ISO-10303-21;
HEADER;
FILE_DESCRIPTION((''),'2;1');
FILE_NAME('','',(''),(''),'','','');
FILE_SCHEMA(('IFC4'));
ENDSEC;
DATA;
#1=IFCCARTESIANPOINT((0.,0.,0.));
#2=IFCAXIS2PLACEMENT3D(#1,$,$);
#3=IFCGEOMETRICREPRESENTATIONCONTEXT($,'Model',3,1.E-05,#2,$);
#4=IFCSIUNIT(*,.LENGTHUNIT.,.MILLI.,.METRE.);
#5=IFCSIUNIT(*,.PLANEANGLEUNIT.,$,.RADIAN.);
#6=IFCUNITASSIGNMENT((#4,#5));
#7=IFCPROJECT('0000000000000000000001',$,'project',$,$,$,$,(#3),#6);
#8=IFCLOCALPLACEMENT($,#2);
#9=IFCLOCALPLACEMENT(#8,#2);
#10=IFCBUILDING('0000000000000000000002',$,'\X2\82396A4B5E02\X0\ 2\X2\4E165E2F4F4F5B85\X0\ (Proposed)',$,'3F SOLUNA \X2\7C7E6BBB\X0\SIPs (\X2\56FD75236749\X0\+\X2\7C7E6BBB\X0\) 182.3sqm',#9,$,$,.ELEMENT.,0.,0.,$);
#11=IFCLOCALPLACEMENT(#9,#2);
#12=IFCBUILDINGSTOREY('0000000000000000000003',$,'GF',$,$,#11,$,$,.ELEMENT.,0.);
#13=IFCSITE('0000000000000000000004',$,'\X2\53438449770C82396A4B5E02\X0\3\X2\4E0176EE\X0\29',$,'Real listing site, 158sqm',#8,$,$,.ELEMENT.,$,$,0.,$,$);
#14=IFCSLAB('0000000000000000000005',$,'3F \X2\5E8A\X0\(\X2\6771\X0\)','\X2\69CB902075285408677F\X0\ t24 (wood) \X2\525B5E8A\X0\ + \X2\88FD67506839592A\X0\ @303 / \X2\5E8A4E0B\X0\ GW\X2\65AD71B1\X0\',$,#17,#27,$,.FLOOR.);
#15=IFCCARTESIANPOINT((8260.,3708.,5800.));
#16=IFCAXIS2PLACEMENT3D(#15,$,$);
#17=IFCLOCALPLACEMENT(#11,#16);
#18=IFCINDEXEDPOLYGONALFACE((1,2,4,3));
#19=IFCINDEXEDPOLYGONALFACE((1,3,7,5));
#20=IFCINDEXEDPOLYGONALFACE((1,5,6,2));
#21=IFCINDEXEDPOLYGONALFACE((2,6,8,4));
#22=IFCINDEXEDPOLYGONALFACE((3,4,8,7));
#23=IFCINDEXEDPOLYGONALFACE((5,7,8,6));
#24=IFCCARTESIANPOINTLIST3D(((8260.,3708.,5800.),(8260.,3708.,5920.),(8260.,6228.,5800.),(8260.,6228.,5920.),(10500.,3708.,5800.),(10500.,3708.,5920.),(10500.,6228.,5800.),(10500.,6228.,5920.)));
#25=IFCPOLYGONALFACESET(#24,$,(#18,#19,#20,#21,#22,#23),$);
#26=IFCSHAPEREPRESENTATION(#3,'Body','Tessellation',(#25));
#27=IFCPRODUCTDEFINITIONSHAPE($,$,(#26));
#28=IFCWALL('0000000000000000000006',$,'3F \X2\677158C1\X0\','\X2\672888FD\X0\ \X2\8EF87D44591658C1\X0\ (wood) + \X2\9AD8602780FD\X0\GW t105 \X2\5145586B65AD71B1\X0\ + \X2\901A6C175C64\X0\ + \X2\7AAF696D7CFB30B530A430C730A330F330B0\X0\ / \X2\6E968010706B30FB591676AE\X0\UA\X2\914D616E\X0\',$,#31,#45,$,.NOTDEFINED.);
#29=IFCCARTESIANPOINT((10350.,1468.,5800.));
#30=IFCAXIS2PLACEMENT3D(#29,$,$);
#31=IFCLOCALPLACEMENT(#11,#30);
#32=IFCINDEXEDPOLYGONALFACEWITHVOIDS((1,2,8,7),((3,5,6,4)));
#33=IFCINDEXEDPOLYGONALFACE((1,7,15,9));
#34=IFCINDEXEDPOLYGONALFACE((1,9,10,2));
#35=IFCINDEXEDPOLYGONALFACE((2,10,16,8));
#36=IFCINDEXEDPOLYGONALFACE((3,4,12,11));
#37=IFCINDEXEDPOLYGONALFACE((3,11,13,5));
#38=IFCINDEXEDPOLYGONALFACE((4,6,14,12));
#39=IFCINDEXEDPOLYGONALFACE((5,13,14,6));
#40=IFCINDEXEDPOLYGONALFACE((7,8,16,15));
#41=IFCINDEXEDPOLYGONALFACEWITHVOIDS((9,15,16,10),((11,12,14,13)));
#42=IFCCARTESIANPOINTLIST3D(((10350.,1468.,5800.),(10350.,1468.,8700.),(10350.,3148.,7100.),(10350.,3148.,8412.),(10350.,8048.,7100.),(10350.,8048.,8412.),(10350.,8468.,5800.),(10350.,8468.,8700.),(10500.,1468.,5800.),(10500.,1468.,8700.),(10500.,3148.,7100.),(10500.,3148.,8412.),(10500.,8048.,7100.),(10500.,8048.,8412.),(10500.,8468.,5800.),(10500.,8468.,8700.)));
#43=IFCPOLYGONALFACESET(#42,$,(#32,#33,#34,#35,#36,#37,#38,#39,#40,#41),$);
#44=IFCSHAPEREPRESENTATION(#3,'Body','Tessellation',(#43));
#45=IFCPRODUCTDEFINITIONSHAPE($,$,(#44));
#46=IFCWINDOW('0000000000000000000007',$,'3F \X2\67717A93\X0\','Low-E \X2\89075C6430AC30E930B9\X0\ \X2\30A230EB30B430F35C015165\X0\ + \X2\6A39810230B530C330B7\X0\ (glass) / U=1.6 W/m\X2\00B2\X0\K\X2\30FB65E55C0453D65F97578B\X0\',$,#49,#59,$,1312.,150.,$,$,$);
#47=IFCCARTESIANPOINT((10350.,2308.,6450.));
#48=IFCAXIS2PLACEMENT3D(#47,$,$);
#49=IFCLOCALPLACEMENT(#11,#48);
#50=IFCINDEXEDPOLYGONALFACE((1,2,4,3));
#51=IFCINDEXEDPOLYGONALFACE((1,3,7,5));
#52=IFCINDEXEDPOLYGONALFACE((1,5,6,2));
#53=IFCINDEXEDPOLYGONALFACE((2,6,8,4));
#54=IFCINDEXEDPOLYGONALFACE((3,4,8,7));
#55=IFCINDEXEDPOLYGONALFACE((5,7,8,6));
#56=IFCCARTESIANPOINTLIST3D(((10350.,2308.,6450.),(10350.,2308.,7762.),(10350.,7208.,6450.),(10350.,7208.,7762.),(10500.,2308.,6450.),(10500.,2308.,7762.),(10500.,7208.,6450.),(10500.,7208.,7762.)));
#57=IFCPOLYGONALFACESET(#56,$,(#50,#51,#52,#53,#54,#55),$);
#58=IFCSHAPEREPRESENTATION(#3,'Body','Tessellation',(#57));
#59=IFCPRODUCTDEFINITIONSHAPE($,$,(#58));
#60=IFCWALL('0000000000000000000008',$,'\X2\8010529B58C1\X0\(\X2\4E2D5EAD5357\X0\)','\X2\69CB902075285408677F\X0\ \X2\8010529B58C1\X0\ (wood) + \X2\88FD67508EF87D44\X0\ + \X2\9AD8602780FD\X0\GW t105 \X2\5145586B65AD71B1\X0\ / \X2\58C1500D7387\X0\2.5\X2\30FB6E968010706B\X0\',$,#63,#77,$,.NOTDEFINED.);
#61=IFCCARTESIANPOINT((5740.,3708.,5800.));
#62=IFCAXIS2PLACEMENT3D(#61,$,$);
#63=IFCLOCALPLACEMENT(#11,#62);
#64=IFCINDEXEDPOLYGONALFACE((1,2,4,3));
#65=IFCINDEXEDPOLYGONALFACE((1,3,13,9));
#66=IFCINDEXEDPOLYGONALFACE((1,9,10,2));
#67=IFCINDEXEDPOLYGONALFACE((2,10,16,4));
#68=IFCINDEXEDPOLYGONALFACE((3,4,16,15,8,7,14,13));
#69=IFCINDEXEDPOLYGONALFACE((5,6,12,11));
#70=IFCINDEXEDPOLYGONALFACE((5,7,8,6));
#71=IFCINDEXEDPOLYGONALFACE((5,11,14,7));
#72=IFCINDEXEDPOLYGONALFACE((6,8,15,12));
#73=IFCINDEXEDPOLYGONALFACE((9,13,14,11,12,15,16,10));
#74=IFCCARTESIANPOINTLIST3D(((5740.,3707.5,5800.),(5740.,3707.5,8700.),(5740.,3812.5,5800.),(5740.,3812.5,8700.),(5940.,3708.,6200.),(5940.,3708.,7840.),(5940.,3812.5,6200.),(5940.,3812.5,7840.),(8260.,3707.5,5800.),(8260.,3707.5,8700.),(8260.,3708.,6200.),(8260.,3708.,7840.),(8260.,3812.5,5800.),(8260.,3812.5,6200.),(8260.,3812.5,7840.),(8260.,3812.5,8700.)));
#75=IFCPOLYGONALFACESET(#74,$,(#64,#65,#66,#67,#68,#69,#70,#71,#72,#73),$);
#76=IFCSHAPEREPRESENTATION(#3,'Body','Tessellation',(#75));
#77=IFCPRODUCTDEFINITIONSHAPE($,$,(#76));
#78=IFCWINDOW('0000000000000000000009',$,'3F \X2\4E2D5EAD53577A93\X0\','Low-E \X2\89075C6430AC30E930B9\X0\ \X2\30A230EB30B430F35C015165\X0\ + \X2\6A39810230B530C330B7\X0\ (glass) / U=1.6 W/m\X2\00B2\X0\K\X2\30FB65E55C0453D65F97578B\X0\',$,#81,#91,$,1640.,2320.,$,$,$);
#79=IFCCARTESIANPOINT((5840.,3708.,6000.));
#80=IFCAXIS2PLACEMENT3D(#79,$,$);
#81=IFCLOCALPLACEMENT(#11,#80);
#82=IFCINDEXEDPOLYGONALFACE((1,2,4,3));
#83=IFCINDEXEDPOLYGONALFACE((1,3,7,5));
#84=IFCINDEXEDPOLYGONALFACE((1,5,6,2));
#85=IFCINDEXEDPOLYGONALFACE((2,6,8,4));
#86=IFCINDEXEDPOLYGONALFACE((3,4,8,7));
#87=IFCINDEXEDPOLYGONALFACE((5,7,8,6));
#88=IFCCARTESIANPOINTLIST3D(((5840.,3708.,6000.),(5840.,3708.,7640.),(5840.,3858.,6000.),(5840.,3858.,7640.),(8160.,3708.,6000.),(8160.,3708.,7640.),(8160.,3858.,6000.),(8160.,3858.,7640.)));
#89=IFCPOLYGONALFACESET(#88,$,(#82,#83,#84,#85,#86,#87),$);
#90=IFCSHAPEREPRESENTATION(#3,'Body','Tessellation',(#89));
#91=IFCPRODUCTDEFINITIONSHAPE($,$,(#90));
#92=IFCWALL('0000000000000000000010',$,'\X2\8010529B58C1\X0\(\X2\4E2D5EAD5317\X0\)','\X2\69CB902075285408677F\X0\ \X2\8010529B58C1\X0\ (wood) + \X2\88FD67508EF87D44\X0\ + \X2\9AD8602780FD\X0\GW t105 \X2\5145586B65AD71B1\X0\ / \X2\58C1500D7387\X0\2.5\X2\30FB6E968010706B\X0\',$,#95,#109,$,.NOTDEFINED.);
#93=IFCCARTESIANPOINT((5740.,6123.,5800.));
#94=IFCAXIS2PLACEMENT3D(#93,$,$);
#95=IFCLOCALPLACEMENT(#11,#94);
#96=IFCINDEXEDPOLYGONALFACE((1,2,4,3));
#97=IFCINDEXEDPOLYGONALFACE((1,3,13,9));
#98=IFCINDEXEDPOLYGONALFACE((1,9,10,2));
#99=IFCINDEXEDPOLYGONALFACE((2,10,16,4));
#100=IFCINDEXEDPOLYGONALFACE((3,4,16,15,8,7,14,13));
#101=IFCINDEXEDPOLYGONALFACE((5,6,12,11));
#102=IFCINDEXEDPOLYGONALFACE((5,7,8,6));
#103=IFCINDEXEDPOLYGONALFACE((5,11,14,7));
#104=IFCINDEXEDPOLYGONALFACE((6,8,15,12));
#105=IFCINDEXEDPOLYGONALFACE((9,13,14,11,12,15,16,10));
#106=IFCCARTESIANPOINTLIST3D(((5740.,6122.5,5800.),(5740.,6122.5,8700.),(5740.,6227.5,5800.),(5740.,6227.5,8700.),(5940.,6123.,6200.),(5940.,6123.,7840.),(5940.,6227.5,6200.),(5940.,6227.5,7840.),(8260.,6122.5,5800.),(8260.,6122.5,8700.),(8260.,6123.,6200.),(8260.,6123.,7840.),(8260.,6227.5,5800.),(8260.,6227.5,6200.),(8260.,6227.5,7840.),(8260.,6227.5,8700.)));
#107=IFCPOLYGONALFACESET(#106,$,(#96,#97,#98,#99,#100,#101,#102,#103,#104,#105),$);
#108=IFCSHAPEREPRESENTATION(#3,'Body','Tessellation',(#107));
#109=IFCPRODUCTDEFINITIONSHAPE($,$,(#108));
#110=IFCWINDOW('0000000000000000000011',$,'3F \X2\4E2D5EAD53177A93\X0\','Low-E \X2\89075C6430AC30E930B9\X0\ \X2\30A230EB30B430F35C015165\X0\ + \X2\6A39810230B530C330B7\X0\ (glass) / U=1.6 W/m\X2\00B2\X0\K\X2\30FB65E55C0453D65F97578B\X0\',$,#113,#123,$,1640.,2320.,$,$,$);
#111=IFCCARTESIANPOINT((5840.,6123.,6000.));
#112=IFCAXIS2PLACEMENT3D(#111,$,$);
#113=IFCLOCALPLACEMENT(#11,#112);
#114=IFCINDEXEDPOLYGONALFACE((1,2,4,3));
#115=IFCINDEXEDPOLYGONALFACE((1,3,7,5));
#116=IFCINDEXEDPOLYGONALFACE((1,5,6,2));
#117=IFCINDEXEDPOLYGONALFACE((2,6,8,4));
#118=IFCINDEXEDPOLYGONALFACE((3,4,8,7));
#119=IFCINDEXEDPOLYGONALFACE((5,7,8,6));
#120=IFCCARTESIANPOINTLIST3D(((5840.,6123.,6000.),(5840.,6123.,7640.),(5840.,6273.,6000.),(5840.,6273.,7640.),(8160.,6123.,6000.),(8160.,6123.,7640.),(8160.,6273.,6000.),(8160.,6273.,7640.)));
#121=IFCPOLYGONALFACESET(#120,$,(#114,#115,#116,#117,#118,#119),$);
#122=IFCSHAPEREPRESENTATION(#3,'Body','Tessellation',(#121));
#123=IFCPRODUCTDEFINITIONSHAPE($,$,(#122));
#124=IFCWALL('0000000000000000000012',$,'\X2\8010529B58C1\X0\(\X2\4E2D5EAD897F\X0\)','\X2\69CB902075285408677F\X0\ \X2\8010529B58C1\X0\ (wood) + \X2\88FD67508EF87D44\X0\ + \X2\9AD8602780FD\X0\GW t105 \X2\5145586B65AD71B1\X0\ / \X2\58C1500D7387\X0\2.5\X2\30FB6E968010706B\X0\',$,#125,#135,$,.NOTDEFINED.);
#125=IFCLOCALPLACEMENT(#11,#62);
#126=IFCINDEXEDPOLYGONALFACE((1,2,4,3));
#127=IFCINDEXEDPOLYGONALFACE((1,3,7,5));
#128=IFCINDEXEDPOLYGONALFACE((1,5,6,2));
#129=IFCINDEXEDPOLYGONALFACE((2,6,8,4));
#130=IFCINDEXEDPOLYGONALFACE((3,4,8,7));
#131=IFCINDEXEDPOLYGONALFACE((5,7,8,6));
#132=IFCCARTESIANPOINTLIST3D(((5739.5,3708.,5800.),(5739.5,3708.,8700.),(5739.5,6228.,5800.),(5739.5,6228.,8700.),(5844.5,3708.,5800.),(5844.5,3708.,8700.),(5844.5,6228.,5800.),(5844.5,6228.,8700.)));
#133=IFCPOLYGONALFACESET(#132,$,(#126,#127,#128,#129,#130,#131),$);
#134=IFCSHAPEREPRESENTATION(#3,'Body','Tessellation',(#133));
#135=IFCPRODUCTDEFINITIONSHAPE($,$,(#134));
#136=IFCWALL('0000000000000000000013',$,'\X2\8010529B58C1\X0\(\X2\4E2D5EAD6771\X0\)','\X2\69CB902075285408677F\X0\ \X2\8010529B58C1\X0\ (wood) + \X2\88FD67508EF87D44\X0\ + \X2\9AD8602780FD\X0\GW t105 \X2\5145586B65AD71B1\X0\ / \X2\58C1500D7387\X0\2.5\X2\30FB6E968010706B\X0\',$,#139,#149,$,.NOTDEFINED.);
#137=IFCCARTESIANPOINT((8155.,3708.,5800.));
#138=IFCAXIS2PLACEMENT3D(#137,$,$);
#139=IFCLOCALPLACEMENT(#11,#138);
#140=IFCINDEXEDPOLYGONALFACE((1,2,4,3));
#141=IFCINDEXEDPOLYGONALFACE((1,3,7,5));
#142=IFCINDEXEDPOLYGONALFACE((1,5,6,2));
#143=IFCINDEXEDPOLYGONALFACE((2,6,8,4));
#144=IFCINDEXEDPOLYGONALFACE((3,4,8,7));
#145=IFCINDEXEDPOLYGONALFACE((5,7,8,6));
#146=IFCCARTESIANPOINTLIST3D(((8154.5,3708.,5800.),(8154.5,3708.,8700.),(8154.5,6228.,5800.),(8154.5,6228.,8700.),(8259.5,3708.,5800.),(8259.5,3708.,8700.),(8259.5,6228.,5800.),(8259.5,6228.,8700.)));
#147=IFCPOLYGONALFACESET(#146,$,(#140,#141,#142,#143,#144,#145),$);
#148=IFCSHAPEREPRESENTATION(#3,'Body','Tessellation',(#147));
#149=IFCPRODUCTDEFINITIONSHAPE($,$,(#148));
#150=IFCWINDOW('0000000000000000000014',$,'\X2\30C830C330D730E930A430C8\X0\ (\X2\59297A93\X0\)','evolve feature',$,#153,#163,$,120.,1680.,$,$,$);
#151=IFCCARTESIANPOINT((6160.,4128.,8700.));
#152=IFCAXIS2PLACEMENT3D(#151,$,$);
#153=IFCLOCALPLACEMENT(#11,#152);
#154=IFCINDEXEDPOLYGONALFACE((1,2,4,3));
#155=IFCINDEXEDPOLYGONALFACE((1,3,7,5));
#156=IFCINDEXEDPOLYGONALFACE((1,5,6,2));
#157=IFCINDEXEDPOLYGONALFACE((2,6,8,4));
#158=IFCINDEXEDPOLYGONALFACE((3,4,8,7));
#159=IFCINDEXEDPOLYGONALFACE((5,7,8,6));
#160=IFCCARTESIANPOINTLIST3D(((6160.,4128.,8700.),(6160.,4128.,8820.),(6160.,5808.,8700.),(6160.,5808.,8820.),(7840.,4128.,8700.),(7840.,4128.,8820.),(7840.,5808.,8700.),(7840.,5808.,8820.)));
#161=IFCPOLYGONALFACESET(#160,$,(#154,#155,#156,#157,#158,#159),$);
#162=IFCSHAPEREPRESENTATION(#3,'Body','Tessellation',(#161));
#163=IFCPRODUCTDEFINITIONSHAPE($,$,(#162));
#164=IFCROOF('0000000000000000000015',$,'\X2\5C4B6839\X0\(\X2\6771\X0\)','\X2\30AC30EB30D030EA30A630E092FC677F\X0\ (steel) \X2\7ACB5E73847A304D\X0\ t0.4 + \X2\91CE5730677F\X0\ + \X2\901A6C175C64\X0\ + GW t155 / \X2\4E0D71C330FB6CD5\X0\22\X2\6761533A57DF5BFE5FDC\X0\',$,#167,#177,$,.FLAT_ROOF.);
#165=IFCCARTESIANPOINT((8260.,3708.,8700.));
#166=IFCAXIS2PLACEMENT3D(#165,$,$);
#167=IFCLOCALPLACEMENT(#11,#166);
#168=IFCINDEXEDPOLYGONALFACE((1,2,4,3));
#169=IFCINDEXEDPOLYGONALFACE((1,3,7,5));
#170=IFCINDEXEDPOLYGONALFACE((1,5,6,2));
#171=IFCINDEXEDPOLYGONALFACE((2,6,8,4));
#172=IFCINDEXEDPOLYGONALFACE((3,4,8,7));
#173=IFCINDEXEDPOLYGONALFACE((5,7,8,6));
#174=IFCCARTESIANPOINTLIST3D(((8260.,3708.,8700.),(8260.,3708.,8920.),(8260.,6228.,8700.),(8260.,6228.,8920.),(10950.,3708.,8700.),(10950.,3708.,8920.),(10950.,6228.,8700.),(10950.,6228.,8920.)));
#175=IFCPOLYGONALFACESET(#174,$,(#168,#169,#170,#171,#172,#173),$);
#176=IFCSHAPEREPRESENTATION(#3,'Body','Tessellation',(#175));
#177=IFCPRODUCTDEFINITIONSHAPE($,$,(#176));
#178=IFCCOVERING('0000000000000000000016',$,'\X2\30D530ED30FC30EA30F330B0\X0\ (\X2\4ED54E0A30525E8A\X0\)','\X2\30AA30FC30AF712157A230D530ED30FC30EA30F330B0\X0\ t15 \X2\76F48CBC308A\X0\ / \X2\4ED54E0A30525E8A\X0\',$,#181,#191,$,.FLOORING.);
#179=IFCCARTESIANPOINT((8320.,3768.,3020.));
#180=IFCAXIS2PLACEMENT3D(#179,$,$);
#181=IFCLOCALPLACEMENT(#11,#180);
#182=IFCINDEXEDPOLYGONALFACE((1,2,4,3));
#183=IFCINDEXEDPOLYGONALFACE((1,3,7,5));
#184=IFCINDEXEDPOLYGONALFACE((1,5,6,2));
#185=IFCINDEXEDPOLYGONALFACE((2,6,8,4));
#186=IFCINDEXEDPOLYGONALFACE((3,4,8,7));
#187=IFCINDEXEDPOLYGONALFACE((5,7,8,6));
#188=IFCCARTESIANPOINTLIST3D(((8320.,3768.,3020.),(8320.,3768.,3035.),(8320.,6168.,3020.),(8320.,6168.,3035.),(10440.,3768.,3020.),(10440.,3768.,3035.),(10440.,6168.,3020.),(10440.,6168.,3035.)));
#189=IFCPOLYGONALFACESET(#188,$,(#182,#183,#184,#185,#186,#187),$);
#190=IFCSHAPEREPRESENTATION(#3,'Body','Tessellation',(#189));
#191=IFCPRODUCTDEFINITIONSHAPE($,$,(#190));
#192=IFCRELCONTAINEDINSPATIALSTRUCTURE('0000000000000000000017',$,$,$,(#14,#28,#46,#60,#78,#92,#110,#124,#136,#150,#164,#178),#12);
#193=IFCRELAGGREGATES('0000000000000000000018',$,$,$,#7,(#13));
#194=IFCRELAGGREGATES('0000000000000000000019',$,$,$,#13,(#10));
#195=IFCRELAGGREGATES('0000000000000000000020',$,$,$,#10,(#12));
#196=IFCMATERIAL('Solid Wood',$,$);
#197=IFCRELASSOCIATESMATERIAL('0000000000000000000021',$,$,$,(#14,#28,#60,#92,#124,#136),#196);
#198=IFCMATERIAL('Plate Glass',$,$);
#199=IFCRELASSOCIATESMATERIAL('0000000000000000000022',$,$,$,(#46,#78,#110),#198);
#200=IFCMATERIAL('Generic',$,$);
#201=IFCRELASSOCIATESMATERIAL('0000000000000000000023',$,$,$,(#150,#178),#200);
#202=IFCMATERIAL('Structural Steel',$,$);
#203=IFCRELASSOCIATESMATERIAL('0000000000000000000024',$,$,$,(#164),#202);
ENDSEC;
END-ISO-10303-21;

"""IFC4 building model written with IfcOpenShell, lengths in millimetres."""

from ifc_helpers import new_model, si_unit, frame, frame_2d, origin, place, context, project, spatial, rectangle, extrude, material, element, fill, save


model = new_model("IFC4")

# Units and contexts
model_context = context("Model", 3, precision=1e-05, world=origin())
ifc_project = project(units=[si_unit("LENGTHUNIT", "METRE", prefix="MILLI"), si_unit("PLANEANGLEUNIT", "RADIAN")], contexts=[model_context])

# Site, building, storey
site_placement = place(None, origin())
site = spatial("IfcSite", under=ifc_project, at=site_placement, Name="千葉県船橋市3丁目29", ObjectType="Real listing site, 158sqm", CompositionType="ELEMENT", RefElevation=0.0)
building_placement = place(site_placement, origin())
building = spatial("IfcBuilding", under=site, at=building_placement, Name="船橋市 2世帯住宅 (Proposed)", ObjectType="3F SOLUNA 籾殻SIPs (国産杉+籾殻) 182.3sqm", CompositionType="ELEMENT", ElevationOfRefHeight=0.0, ElevationOfTerrain=0.0)
storey_placement = place(building_placement, origin())
storey = spatial("IfcBuildingStorey", under=building, at=storey_placement, Name="GF", CompositionType="ELEMENT", Elevation=0.0)

# Slab
ifc_material_1 = material(Name="Solid Wood")
slab_placement = place(storey_placement, frame((8260.0, 3708.0, 5800.0)))
element("IfcSlab", 1, at=slab_placement, inside=storey, material=ifc_material_1, Name="3F 床(東)", Description="構造用合板 t24 (wood) 剛床 + 製材根太 @303 / 床下 GW断熱", PredefinedType="FLOOR", context=model_context, shape_type="SweptSolid", body=[
    extrude(rectangle(XDim=2240.0, YDim=2520.0, at=frame_2d((1120.0, 1260.0))), frame((8260.0, 3708.0, 5800.0)), (0.0, 0.0, 1.0), 120.0),
])

# Walls, openings, windows
wall_1_placement = place(storey_placement, frame((10350.0, 1468.0, 5800.0)))
wall_1 = element("IfcWall", 2, at=wall_1_placement, inside=storey, material=ifc_material_1, Name="3F 東壁", Description="木製 軸組外壁 (wood) + 高性能GW t105 充填断熱 + 通気層 + 窯業系サイディング / 準耐火・外皮UA配慮", PredefinedType="NOTDEFINED", context=model_context, shape_type="SweptSolid", body=[
    extrude(rectangle(XDim=150.0, YDim=7000.0, at=frame_2d((75.0, 3500.0))), frame((10350.0, 1468.0, 5800.0)), (0.0, 0.0, 1.0), 2900.0),
])
opening_1_placement = place(storey_placement, frame((10350.0, 2308.0, 6450.0)))
opening_1 = element("IfcOpeningElement", 3, at=opening_1_placement, cuts=wall_1, PredefinedType="NOTDEFINED", context=model_context, shape_type="SweptSolid", body=[
    extrude(rectangle(XDim=150.0, YDim=4900.0, at=frame_2d((75.0, 2450.0))), frame((10350.0, 2308.0, 6450.0)), (0.0, 0.0, 1.0), 1312.0),
])
ifc_material_2 = material(Name="Plate Glass")
window_1_placement = place(storey_placement, frame((10350.0, 2308.0, 6450.0)))
window_1 = element("IfcWindow", 4, at=window_1_placement, inside=storey, material=ifc_material_2, Name="3F 東窓", Description="Low-E 複層ガラス アルゴン封入 + 樹脂サッシ (glass) / U=1.6 W/m²K・日射取得型", OverallHeight=1312.0, OverallWidth=150.0, context=model_context, shape_type="SweptSolid", body=[
    extrude(rectangle(XDim=150.0, YDim=4900.0, at=frame_2d((75.0, 2450.0))), frame((10350.0, 2308.0, 6450.0)), (0.0, 0.0, 1.0), 1312.0),
])
fill(opening_1, window_1)
wall_2_placement = place(storey_placement, frame((5740.0, 3708.0, 5800.0)))
wall_2 = element("IfcWall", 5, at=wall_2_placement, inside=storey, material=ifc_material_1, Name="耐力壁(中庭南)", Description="構造用合板 耐力壁 (wood) + 製材軸組 + 高性能GW t105 充填断熱 / 壁倍率2.5・準耐火", PredefinedType="NOTDEFINED", context=model_context, shape_type="SweptSolid", body=[
    extrude(rectangle(XDim=2520.0, YDim=105.0, at=frame_2d((1260.0, 52.0))), frame((5740.0, 3708.0, 5800.0)), (0.0, 0.0, 1.0), 2900.0),
])
opening_2_placement = place(storey_placement, frame((5840.0, 3708.0, 6000.0)))
opening_2 = element("IfcOpeningElement", 6, at=opening_2_placement, cuts=wall_2, PredefinedType="NOTDEFINED", context=model_context, shape_type="SweptSolid", body=[
    extrude(rectangle(XDim=2320.0, YDim=150.0, at=frame_2d((1160.0, 75.0))), frame((5840.0, 3708.0, 6000.0)), (0.0, 0.0, 1.0), 1640.0),
])
window_2_placement = place(storey_placement, frame((5840.0, 3708.0, 6000.0)))
window_2 = element("IfcWindow", 7, at=window_2_placement, inside=storey, material=ifc_material_2, Name="3F 中庭南窓", Description="Low-E 複層ガラス アルゴン封入 + 樹脂サッシ (glass) / U=1.6 W/m²K・日射取得型", OverallHeight=1640.0, OverallWidth=2320.0, context=model_context, shape_type="SweptSolid", body=[
    extrude(rectangle(XDim=2320.0, YDim=150.0, at=frame_2d((1160.0, 75.0))), frame((5840.0, 3708.0, 6000.0)), (0.0, 0.0, 1.0), 1640.0),
])
fill(opening_2, window_2)
wall_3_placement = place(storey_placement, frame((5740.0, 6123.0, 5800.0)))
wall_3 = element("IfcWall", 8, at=wall_3_placement, inside=storey, material=ifc_material_1, Name="耐力壁(中庭北)", Description="構造用合板 耐力壁 (wood) + 製材軸組 + 高性能GW t105 充填断熱 / 壁倍率2.5・準耐火", PredefinedType="NOTDEFINED", context=model_context, shape_type="SweptSolid", body=[
    extrude(rectangle(XDim=2520.0, YDim=105.0, at=frame_2d((1260.0, 52.0))), frame((5740.0, 6123.0, 5800.0)), (0.0, 0.0, 1.0), 2900.0),
])
opening_3_placement = place(storey_placement, frame((5840.0, 6123.0, 6000.0)))
opening_3 = element("IfcOpeningElement", 9, at=opening_3_placement, cuts=wall_3, PredefinedType="NOTDEFINED", context=model_context, shape_type="SweptSolid", body=[
    extrude(rectangle(XDim=2320.0, YDim=150.0, at=frame_2d((1160.0, 75.0))), frame((5840.0, 6123.0, 6000.0)), (0.0, 0.0, 1.0), 1640.0),
])
window_3_placement = place(storey_placement, frame((5840.0, 6123.0, 6000.0)))
window_3 = element("IfcWindow", 10, at=window_3_placement, inside=storey, material=ifc_material_2, Name="3F 中庭北窓", Description="Low-E 複層ガラス アルゴン封入 + 樹脂サッシ (glass) / U=1.6 W/m²K・日射取得型", OverallHeight=1640.0, OverallWidth=2320.0, context=model_context, shape_type="SweptSolid", body=[
    extrude(rectangle(XDim=2320.0, YDim=150.0, at=frame_2d((1160.0, 75.0))), frame((5840.0, 6123.0, 6000.0)), (0.0, 0.0, 1.0), 1640.0),
])
fill(opening_3, window_3)

# Walls
wall_4_placement = place(storey_placement, frame((5740.0, 3708.0, 5800.0)))
element("IfcWall", 11, at=wall_4_placement, inside=storey, material=ifc_material_1, Name="耐力壁(中庭西)", Description="構造用合板 耐力壁 (wood) + 製材軸組 + 高性能GW t105 充填断熱 / 壁倍率2.5・準耐火", PredefinedType="NOTDEFINED", context=model_context, shape_type="SweptSolid", body=[
    extrude(rectangle(XDim=105.0, YDim=2520.0, at=frame_2d((52.0, 1260.0))), frame((5740.0, 3708.0, 5800.0)), (0.0, 0.0, 1.0), 2900.0),
])
wall_5_placement = place(storey_placement, frame((8155.0, 3708.0, 5800.0)))
element("IfcWall", 12, at=wall_5_placement, inside=storey, material=ifc_material_1, Name="耐力壁(中庭東)", Description="構造用合板 耐力壁 (wood) + 製材軸組 + 高性能GW t105 充填断熱 / 壁倍率2.5・準耐火", PredefinedType="NOTDEFINED", context=model_context, shape_type="SweptSolid", body=[
    extrude(rectangle(XDim=105.0, YDim=2520.0, at=frame_2d((52.0, 1260.0))), frame((8155.0, 3708.0, 5800.0)), (0.0, 0.0, 1.0), 2900.0),
])

# Window
ifc_material_3 = material(Name="Generic")
window_4_placement = place(storey_placement, frame((6160.0, 4128.0, 8700.0)))
element("IfcWindow", 13, at=window_4_placement, inside=storey, material=ifc_material_3, Name="トップライト (天窓)", Description="evolve feature", OverallHeight=120.0, OverallWidth=1680.0, context=model_context, shape_type="SweptSolid", body=[
    extrude(rectangle(XDim=1680.0, YDim=1680.0, at=frame_2d((840.0, 840.0))), frame((6160.0, 4128.0, 8700.0)), (0.0, 0.0, 1.0), 120.0),
])

# Roof
ifc_material_4 = material(Name="Structural Steel")
for number, where, name in (
    (14, (8260.0, 3708.0, 8700.0), "屋根(東)"),
):
    element("IfcRoof", number, at=place(storey_placement, frame(where)), inside=storey, material=ifc_material_4, Name=name, Description="ガルバリウム鋼板 (steel) 立平葺き t0.4 + 野地板 + 通気層 + GW t155 / 不燃・法22条区域対応", PredefinedType="FLAT_ROOF", context=model_context, shape_type="SweptSolid", body=[
        extrude(rectangle(XDim=2690.0, YDim=2520.0, at=frame_2d((1345.0, 1260.0))), frame((8260.0, 3708.0, 8700.0)), (0.0, 0.0, 1.0), 220.0),
    ])

# Covering
covering_1_placement = place(storey_placement, frame((8320.0, 3768.0, 3020.0)))
element("IfcCovering", 15, at=covering_1_placement, inside=storey, material=ifc_material_3, Name="フローリング (仕上げ床)", Description="オーク無垢フローリング t15 直貼り / 仕上げ床", PredefinedType="FLOORING", context=model_context, shape_type="SweptSolid", body=[
    extrude(rectangle(XDim=2120.0, YDim=2400.0, at=frame_2d((1060.0, 1200.0))), frame((8320.0, 3768.0, 3020.0)), (0.0, 0.0, 1.0), 15.0),
])

save(model, "model.ifc")
